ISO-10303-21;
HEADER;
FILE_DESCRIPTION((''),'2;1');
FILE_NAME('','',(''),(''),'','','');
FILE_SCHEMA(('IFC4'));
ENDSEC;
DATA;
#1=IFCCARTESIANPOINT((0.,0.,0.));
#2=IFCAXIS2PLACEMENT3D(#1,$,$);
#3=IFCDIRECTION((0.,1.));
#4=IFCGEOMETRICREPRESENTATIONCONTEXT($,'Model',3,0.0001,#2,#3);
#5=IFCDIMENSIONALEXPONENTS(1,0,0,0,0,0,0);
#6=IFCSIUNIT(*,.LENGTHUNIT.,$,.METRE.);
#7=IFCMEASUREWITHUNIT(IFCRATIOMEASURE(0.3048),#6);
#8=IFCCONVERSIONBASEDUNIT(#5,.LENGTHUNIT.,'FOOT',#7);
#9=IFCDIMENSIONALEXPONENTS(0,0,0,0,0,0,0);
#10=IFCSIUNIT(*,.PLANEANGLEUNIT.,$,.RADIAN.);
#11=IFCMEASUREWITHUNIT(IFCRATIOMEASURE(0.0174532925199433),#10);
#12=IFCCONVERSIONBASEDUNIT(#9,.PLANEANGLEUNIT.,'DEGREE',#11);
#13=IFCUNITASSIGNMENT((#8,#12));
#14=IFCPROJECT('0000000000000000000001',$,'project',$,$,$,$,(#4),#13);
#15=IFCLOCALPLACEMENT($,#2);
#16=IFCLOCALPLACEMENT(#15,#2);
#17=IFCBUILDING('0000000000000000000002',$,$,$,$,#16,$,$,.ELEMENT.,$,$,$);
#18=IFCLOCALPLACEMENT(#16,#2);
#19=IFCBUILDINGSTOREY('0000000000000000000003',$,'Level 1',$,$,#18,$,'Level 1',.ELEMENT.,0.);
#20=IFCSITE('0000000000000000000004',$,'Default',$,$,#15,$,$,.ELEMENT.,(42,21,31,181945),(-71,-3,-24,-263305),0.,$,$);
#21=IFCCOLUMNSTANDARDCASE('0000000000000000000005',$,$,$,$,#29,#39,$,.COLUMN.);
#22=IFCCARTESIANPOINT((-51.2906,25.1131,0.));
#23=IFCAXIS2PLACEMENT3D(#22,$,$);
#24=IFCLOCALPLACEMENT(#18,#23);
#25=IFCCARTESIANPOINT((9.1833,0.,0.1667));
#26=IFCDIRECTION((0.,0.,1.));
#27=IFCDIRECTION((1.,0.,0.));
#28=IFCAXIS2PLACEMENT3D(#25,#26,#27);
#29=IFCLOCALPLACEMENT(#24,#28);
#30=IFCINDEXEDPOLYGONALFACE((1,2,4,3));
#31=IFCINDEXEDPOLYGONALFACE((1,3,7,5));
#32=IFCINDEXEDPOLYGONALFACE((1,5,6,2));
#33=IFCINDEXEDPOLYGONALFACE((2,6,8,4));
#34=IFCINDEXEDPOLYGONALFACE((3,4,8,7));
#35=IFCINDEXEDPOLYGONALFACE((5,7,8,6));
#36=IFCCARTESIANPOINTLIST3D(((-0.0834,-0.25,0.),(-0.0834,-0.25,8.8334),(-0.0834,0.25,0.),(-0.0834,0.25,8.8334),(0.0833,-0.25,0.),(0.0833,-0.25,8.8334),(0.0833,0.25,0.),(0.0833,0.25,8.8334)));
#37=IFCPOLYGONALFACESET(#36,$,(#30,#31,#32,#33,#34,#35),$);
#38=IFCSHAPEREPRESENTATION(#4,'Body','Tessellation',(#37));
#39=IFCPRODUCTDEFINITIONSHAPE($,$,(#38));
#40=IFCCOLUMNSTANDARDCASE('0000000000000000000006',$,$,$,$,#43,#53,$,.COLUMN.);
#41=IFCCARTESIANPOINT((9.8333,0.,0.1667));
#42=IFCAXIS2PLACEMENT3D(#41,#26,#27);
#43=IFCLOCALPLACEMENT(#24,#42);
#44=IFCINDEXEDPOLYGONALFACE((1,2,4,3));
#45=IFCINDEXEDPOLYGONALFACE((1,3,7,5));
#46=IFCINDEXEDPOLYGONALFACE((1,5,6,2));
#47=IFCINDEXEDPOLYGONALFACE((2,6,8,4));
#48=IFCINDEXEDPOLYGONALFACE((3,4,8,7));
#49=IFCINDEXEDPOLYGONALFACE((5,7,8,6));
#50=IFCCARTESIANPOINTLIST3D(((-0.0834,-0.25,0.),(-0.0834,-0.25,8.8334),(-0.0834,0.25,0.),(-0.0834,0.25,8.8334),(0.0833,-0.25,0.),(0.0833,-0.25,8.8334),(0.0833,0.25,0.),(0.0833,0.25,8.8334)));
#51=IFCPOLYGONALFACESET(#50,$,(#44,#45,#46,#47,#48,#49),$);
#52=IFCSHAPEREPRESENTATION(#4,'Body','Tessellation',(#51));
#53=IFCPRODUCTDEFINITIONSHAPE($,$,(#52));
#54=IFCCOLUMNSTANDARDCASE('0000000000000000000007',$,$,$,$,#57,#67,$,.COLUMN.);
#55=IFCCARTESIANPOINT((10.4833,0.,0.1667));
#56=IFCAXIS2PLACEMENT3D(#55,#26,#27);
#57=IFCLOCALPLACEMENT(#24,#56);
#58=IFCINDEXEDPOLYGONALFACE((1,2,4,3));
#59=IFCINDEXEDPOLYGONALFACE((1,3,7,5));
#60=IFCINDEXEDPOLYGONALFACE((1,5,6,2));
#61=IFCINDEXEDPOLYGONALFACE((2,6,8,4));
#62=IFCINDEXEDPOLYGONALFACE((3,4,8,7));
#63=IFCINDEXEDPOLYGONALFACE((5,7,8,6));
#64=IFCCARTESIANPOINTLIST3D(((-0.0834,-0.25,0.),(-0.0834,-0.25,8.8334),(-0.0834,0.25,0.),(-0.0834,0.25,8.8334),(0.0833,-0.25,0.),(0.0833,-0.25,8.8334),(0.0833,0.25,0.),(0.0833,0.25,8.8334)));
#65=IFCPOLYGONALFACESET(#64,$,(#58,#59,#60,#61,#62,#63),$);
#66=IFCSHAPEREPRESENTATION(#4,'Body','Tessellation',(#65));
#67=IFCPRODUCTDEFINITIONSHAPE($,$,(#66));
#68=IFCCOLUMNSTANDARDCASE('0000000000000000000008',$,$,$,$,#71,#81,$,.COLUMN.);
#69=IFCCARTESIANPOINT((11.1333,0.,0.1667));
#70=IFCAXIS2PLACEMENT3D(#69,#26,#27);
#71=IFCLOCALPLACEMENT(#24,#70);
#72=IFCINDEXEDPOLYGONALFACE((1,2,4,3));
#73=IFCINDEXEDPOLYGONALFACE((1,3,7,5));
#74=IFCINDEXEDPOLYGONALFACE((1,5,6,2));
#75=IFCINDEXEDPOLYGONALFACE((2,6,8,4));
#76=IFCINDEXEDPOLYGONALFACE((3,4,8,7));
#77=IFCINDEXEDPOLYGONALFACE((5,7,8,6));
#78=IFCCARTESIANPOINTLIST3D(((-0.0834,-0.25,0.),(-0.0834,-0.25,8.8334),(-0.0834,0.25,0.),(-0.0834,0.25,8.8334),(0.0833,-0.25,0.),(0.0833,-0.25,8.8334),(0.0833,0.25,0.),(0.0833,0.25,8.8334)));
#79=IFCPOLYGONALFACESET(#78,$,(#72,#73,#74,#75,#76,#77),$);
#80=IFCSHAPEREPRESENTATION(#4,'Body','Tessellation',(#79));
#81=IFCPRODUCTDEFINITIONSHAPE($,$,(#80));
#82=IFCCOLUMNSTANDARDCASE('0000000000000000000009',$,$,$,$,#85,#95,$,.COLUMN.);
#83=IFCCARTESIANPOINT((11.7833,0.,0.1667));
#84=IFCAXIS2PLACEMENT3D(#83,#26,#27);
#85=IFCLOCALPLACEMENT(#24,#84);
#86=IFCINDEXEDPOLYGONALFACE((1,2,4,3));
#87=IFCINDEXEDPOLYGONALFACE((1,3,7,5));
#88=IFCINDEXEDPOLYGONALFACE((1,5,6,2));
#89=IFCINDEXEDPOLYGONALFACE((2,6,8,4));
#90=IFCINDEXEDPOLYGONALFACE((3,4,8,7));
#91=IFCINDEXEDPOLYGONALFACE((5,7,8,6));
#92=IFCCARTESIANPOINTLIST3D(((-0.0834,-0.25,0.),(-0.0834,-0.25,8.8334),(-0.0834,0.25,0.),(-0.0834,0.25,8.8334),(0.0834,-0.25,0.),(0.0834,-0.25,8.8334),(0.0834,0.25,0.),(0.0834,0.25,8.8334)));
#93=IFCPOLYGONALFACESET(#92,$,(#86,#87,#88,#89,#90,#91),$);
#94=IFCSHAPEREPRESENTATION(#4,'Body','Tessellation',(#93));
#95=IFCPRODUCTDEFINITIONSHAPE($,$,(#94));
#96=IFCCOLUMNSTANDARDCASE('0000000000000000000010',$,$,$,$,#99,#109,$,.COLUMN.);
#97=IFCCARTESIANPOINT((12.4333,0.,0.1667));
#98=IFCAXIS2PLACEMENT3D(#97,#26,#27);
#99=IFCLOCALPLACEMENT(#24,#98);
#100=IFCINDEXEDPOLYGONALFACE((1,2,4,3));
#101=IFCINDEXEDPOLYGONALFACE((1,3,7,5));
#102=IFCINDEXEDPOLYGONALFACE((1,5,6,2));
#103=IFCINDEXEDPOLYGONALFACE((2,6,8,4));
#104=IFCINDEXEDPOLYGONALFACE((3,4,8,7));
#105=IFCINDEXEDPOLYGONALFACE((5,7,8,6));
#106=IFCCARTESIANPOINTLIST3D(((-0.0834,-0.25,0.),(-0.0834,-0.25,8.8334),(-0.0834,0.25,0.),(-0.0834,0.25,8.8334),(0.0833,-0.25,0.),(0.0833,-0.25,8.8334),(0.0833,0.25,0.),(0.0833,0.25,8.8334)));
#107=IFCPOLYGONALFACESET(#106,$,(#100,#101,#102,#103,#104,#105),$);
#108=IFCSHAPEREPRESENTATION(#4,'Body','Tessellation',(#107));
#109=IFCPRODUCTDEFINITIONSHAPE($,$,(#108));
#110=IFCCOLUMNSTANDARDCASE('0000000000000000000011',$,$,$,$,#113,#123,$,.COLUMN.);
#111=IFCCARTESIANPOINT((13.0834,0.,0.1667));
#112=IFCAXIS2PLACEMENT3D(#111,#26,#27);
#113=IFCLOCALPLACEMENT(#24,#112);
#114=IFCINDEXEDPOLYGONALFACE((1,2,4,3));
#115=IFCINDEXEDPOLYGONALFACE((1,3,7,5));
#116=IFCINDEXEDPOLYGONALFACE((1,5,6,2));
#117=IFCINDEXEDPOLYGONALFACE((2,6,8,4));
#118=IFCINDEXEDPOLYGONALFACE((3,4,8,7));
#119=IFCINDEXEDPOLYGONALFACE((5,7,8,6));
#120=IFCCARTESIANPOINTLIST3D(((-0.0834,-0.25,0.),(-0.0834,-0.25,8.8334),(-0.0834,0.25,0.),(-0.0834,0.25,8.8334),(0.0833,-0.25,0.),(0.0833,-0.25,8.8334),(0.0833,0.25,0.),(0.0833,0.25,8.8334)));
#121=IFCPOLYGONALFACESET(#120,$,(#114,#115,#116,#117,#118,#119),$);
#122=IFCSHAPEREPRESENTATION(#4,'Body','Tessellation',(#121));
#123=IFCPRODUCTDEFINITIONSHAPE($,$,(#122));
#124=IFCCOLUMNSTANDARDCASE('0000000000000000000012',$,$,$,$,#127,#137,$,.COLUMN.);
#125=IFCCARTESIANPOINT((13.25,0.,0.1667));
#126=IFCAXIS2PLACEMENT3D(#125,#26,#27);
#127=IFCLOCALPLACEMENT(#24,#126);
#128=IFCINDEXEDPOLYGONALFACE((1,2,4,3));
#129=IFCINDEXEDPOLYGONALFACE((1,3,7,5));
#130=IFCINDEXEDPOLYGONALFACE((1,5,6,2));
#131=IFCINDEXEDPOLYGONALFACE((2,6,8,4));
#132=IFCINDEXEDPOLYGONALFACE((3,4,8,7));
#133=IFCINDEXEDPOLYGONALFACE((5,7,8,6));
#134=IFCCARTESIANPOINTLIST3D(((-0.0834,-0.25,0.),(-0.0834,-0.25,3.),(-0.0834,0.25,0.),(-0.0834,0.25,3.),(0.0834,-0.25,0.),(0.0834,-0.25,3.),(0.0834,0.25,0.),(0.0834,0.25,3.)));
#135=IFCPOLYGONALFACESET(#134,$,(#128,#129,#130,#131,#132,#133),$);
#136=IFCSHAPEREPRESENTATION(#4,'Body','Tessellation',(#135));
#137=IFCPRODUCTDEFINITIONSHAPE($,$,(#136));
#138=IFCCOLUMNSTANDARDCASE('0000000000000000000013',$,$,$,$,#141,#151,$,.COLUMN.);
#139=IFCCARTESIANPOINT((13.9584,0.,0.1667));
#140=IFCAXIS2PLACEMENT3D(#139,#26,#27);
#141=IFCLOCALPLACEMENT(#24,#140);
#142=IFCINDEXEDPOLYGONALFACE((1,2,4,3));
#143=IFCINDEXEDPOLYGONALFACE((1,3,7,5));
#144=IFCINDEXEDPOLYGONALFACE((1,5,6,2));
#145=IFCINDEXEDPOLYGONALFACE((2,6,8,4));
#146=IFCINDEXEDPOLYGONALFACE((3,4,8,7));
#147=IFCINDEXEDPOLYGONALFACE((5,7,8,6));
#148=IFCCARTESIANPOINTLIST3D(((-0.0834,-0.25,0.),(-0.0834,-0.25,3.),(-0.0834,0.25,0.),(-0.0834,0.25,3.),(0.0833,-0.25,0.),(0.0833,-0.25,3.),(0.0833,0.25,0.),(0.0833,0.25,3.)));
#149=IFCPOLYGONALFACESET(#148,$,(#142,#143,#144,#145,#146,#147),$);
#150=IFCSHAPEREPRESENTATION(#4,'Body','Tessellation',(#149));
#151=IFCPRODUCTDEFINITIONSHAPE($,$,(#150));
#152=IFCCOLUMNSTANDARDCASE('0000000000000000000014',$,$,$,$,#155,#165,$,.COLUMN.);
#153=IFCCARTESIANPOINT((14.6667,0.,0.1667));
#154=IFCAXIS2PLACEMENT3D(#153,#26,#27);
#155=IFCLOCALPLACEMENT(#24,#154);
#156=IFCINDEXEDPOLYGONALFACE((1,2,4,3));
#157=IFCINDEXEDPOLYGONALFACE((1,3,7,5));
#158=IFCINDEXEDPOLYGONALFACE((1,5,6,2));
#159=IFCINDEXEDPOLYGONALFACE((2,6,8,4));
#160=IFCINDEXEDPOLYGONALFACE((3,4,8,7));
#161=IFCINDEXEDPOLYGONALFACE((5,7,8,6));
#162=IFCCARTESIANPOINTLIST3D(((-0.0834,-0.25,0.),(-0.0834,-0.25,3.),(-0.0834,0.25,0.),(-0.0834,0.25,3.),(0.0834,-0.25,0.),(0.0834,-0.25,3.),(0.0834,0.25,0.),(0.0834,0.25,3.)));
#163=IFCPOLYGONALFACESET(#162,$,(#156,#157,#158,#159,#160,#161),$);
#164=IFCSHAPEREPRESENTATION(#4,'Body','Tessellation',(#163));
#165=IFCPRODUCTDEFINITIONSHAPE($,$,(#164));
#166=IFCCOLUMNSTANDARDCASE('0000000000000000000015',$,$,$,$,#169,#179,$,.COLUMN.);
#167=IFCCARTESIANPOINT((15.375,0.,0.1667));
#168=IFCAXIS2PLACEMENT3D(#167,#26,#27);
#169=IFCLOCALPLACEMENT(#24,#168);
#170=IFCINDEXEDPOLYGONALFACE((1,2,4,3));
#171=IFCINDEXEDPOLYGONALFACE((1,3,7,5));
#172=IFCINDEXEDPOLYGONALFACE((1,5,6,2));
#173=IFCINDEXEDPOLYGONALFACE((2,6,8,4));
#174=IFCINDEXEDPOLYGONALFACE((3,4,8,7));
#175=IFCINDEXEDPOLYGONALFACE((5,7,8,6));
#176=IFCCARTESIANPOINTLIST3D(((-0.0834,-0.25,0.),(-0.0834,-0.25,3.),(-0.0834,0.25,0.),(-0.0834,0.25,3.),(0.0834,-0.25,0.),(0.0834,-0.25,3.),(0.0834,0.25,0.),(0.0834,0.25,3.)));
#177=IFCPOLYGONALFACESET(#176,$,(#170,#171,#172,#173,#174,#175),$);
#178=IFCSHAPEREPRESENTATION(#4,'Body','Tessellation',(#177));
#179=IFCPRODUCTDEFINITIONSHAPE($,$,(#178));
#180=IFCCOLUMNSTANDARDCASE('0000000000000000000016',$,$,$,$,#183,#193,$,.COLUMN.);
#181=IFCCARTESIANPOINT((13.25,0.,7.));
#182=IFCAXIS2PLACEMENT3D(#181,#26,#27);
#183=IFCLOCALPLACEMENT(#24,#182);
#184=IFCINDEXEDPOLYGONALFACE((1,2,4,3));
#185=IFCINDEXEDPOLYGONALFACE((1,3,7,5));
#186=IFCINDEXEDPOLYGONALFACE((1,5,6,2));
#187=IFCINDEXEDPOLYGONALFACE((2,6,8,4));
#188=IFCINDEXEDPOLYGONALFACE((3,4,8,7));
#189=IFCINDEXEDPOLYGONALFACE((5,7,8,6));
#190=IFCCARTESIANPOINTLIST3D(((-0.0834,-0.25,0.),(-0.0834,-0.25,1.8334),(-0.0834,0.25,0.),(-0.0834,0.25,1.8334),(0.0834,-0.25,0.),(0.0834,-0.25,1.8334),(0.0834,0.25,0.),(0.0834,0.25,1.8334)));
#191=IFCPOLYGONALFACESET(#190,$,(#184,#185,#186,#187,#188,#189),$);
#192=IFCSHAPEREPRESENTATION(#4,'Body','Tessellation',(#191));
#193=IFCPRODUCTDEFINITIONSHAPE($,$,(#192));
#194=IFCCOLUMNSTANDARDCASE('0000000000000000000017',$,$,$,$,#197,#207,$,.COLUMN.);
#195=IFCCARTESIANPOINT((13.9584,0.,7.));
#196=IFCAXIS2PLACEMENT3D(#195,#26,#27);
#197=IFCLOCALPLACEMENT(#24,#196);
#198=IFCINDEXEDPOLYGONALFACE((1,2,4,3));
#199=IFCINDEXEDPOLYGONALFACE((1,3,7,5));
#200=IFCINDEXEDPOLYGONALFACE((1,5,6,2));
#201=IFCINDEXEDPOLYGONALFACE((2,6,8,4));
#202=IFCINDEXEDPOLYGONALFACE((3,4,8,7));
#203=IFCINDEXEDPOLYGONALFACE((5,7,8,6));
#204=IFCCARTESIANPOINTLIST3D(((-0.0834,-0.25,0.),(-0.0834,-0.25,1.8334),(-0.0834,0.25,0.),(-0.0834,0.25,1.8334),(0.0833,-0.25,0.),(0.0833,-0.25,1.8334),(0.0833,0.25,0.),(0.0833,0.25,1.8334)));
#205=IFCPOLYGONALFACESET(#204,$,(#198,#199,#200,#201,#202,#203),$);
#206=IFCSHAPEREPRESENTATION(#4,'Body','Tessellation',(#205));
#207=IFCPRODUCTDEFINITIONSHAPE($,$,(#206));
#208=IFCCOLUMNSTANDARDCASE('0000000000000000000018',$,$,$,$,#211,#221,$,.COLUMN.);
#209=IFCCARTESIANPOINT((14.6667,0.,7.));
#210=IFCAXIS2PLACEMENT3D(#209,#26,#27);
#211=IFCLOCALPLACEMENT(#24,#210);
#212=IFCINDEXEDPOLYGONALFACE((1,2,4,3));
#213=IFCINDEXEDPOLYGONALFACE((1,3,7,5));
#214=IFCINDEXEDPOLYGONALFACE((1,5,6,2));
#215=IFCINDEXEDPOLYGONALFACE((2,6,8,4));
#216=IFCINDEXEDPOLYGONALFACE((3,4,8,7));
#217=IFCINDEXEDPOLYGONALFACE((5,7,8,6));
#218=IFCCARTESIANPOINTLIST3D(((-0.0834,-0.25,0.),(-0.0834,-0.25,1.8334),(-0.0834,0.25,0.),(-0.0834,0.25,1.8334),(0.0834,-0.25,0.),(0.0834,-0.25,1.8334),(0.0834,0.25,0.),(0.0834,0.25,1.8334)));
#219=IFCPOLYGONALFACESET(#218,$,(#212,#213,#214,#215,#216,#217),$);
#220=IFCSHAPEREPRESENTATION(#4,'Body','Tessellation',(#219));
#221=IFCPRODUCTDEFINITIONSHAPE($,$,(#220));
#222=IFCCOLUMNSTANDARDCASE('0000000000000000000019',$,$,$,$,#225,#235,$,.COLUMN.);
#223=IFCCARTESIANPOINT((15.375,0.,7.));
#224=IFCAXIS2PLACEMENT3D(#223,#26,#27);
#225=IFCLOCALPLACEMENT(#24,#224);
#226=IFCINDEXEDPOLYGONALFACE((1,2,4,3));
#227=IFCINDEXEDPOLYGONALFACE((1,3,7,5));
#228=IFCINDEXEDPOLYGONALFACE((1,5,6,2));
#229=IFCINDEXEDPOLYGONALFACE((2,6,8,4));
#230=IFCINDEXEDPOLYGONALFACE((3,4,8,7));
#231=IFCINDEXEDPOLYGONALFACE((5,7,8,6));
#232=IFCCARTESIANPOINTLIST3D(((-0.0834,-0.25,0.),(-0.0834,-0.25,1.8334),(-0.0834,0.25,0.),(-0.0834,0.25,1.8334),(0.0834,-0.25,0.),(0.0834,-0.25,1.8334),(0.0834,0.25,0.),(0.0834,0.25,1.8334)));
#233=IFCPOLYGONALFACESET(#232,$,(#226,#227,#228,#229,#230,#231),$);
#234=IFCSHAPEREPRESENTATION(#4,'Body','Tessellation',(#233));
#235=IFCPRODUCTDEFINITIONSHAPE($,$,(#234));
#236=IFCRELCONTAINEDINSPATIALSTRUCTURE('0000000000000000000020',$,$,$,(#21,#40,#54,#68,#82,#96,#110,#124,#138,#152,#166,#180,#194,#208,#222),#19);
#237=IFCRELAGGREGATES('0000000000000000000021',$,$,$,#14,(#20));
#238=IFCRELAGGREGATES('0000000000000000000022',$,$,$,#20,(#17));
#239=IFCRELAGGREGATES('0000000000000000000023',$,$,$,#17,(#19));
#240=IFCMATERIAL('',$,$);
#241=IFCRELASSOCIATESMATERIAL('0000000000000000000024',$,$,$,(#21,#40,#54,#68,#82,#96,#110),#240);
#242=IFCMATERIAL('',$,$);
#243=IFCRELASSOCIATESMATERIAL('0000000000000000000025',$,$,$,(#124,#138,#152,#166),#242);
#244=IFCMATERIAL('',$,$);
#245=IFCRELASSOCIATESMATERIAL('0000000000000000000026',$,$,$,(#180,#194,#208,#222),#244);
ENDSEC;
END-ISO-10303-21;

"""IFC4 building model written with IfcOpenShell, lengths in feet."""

from ifc_helpers import new_model, entity, si_unit, converted_unit, direction, frame, origin, place, context, project, spatial, rectangle, extrude, material, element, save


model = new_model("IFC4")

# Units and contexts
model_context = context("Model", 3, precision=0.0001, world=origin(), true_north=direction((0.0, 1.0)))
ifc_project = project(units=[converted_unit("LENGTHUNIT", "FOOT", entity("IfcRatioMeasure", 0.3048), si_unit("LENGTHUNIT", "METRE"), dimensions=[1, 0, 0, 0, 0, 0, 0]), converted_unit("PLANEANGLEUNIT", "DEGREE", entity("IfcRatioMeasure", 0.0174532925199433), si_unit("PLANEANGLEUNIT", "RADIAN"), dimensions=[0, 0, 0, 0, 0, 0, 0])], contexts=[model_context])

# Site, building, storey
site_placement = place(None, origin())
site = spatial("IfcSite", under=ifc_project, at=site_placement, Name="Default", CompositionType="ELEMENT", RefLatitude=(42, 21, 31, 181945), RefLongitude=(-71, -3, -24, -263305), RefElevation=0.0)
building_placement = place(site_placement, origin())
building = spatial("IfcBuilding", under=site, at=building_placement, CompositionType="ELEMENT")
storey_placement = place(building_placement, origin())
storey = spatial("IfcBuildingStorey", under=building, at=storey_placement, Name="Level 1", LongName="Level 1", CompositionType="ELEMENT", Elevation=0.0)

# Columns
ifc_material_1 = material(Name="")
placement_1 = place(storey_placement, frame((-51.2906, 25.1131, 0.0)))
for number, where, z_axis, x_axis in (
    (1, (9.1833, 0.0, 0.1667), (0.0, 0.0, 1.0), (1.0, 0.0, 0.0)),
    (2, (9.8333, 0.0, 0.1667), (0.0, 0.0, 1.0), (1.0, 0.0, 0.0)),
    (3, (10.4833, 0.0, 0.1667), (0.0, 0.0, 1.0), (1.0, 0.0, 0.0)),
    (4, (11.1333, 0.0, 0.1667), (0.0, 0.0, 1.0), (1.0, 0.0, 0.0)),
    (5, (11.7833, 0.0, 0.1667), (0.0, 0.0, 1.0), (1.0, 0.0, 0.0)),
    (6, (12.4333, 0.0, 0.1667), (0.0, 0.0, 1.0), (1.0, 0.0, 0.0)),
    (7, (13.0834, 0.0, 0.1667), (0.0, 0.0, 1.0), (1.0, 0.0, 0.0)),
):
    element("IfcColumnStandardCase", number, at=place(placement_1, frame(where, z_axis=z_axis, x_axis=x_axis)), inside=storey, material=ifc_material_1, PredefinedType="COLUMN", context=model_context, shape_type="SweptSolid", body=[
        extrude(rectangle(XDim=0.1667, YDim=0.5), origin(), (0.0, 0.0, 1.0), 8.8334),
    ])
ifc_material_2 = material(Name="")
for number, where, z_axis, x_axis in (
    (8, (13.25, 0.0, 0.1667), (0.0, 0.0, 1.0), (1.0, 0.0, 0.0)),
    (9, (13.9584, 0.0, 0.1667), (0.0, 0.0, 1.0), (1.0, 0.0, 0.0)),
    (10, (14.6667, 0.0, 0.1667), (0.0, 0.0, 1.0), (1.0, 0.0, 0.0)),
    (11, (15.375, 0.0, 0.1667), (0.0, 0.0, 1.0), (1.0, 0.0, 0.0)),
):
    element("IfcColumnStandardCase", number, at=place(placement_1, frame(where, z_axis=z_axis, x_axis=x_axis)), inside=storey, material=ifc_material_2, PredefinedType="COLUMN", context=model_context, shape_type="SweptSolid", body=[
        extrude(rectangle(XDim=0.1667, YDim=0.5), origin(), (0.0, 0.0, 1.0), 3.0),
    ])
ifc_material_3 = material(Name="")
for number, where, z_axis, x_axis in (
    (12, (13.25, 0.0, 7.0), (0.0, 0.0, 1.0), (1.0, 0.0, 0.0)),
    (13, (13.9584, 0.0, 7.0), (0.0, 0.0, 1.0), (1.0, 0.0, 0.0)),
    (14, (14.6667, 0.0, 7.0), (0.0, 0.0, 1.0), (1.0, 0.0, 0.0)),
    (15, (15.375, 0.0, 7.0), (0.0, 0.0, 1.0), (1.0, 0.0, 0.0)),
):
    element("IfcColumnStandardCase", number, at=place(placement_1, frame(where, z_axis=z_axis, x_axis=x_axis)), inside=storey, material=ifc_material_3, PredefinedType="COLUMN", context=model_context, shape_type="SweptSolid", body=[
        extrude(rectangle(XDim=0.1667, YDim=0.5), origin(), (0.0, 0.0, 1.0), 1.8334),
    ])

save(model, "model.ifc")
